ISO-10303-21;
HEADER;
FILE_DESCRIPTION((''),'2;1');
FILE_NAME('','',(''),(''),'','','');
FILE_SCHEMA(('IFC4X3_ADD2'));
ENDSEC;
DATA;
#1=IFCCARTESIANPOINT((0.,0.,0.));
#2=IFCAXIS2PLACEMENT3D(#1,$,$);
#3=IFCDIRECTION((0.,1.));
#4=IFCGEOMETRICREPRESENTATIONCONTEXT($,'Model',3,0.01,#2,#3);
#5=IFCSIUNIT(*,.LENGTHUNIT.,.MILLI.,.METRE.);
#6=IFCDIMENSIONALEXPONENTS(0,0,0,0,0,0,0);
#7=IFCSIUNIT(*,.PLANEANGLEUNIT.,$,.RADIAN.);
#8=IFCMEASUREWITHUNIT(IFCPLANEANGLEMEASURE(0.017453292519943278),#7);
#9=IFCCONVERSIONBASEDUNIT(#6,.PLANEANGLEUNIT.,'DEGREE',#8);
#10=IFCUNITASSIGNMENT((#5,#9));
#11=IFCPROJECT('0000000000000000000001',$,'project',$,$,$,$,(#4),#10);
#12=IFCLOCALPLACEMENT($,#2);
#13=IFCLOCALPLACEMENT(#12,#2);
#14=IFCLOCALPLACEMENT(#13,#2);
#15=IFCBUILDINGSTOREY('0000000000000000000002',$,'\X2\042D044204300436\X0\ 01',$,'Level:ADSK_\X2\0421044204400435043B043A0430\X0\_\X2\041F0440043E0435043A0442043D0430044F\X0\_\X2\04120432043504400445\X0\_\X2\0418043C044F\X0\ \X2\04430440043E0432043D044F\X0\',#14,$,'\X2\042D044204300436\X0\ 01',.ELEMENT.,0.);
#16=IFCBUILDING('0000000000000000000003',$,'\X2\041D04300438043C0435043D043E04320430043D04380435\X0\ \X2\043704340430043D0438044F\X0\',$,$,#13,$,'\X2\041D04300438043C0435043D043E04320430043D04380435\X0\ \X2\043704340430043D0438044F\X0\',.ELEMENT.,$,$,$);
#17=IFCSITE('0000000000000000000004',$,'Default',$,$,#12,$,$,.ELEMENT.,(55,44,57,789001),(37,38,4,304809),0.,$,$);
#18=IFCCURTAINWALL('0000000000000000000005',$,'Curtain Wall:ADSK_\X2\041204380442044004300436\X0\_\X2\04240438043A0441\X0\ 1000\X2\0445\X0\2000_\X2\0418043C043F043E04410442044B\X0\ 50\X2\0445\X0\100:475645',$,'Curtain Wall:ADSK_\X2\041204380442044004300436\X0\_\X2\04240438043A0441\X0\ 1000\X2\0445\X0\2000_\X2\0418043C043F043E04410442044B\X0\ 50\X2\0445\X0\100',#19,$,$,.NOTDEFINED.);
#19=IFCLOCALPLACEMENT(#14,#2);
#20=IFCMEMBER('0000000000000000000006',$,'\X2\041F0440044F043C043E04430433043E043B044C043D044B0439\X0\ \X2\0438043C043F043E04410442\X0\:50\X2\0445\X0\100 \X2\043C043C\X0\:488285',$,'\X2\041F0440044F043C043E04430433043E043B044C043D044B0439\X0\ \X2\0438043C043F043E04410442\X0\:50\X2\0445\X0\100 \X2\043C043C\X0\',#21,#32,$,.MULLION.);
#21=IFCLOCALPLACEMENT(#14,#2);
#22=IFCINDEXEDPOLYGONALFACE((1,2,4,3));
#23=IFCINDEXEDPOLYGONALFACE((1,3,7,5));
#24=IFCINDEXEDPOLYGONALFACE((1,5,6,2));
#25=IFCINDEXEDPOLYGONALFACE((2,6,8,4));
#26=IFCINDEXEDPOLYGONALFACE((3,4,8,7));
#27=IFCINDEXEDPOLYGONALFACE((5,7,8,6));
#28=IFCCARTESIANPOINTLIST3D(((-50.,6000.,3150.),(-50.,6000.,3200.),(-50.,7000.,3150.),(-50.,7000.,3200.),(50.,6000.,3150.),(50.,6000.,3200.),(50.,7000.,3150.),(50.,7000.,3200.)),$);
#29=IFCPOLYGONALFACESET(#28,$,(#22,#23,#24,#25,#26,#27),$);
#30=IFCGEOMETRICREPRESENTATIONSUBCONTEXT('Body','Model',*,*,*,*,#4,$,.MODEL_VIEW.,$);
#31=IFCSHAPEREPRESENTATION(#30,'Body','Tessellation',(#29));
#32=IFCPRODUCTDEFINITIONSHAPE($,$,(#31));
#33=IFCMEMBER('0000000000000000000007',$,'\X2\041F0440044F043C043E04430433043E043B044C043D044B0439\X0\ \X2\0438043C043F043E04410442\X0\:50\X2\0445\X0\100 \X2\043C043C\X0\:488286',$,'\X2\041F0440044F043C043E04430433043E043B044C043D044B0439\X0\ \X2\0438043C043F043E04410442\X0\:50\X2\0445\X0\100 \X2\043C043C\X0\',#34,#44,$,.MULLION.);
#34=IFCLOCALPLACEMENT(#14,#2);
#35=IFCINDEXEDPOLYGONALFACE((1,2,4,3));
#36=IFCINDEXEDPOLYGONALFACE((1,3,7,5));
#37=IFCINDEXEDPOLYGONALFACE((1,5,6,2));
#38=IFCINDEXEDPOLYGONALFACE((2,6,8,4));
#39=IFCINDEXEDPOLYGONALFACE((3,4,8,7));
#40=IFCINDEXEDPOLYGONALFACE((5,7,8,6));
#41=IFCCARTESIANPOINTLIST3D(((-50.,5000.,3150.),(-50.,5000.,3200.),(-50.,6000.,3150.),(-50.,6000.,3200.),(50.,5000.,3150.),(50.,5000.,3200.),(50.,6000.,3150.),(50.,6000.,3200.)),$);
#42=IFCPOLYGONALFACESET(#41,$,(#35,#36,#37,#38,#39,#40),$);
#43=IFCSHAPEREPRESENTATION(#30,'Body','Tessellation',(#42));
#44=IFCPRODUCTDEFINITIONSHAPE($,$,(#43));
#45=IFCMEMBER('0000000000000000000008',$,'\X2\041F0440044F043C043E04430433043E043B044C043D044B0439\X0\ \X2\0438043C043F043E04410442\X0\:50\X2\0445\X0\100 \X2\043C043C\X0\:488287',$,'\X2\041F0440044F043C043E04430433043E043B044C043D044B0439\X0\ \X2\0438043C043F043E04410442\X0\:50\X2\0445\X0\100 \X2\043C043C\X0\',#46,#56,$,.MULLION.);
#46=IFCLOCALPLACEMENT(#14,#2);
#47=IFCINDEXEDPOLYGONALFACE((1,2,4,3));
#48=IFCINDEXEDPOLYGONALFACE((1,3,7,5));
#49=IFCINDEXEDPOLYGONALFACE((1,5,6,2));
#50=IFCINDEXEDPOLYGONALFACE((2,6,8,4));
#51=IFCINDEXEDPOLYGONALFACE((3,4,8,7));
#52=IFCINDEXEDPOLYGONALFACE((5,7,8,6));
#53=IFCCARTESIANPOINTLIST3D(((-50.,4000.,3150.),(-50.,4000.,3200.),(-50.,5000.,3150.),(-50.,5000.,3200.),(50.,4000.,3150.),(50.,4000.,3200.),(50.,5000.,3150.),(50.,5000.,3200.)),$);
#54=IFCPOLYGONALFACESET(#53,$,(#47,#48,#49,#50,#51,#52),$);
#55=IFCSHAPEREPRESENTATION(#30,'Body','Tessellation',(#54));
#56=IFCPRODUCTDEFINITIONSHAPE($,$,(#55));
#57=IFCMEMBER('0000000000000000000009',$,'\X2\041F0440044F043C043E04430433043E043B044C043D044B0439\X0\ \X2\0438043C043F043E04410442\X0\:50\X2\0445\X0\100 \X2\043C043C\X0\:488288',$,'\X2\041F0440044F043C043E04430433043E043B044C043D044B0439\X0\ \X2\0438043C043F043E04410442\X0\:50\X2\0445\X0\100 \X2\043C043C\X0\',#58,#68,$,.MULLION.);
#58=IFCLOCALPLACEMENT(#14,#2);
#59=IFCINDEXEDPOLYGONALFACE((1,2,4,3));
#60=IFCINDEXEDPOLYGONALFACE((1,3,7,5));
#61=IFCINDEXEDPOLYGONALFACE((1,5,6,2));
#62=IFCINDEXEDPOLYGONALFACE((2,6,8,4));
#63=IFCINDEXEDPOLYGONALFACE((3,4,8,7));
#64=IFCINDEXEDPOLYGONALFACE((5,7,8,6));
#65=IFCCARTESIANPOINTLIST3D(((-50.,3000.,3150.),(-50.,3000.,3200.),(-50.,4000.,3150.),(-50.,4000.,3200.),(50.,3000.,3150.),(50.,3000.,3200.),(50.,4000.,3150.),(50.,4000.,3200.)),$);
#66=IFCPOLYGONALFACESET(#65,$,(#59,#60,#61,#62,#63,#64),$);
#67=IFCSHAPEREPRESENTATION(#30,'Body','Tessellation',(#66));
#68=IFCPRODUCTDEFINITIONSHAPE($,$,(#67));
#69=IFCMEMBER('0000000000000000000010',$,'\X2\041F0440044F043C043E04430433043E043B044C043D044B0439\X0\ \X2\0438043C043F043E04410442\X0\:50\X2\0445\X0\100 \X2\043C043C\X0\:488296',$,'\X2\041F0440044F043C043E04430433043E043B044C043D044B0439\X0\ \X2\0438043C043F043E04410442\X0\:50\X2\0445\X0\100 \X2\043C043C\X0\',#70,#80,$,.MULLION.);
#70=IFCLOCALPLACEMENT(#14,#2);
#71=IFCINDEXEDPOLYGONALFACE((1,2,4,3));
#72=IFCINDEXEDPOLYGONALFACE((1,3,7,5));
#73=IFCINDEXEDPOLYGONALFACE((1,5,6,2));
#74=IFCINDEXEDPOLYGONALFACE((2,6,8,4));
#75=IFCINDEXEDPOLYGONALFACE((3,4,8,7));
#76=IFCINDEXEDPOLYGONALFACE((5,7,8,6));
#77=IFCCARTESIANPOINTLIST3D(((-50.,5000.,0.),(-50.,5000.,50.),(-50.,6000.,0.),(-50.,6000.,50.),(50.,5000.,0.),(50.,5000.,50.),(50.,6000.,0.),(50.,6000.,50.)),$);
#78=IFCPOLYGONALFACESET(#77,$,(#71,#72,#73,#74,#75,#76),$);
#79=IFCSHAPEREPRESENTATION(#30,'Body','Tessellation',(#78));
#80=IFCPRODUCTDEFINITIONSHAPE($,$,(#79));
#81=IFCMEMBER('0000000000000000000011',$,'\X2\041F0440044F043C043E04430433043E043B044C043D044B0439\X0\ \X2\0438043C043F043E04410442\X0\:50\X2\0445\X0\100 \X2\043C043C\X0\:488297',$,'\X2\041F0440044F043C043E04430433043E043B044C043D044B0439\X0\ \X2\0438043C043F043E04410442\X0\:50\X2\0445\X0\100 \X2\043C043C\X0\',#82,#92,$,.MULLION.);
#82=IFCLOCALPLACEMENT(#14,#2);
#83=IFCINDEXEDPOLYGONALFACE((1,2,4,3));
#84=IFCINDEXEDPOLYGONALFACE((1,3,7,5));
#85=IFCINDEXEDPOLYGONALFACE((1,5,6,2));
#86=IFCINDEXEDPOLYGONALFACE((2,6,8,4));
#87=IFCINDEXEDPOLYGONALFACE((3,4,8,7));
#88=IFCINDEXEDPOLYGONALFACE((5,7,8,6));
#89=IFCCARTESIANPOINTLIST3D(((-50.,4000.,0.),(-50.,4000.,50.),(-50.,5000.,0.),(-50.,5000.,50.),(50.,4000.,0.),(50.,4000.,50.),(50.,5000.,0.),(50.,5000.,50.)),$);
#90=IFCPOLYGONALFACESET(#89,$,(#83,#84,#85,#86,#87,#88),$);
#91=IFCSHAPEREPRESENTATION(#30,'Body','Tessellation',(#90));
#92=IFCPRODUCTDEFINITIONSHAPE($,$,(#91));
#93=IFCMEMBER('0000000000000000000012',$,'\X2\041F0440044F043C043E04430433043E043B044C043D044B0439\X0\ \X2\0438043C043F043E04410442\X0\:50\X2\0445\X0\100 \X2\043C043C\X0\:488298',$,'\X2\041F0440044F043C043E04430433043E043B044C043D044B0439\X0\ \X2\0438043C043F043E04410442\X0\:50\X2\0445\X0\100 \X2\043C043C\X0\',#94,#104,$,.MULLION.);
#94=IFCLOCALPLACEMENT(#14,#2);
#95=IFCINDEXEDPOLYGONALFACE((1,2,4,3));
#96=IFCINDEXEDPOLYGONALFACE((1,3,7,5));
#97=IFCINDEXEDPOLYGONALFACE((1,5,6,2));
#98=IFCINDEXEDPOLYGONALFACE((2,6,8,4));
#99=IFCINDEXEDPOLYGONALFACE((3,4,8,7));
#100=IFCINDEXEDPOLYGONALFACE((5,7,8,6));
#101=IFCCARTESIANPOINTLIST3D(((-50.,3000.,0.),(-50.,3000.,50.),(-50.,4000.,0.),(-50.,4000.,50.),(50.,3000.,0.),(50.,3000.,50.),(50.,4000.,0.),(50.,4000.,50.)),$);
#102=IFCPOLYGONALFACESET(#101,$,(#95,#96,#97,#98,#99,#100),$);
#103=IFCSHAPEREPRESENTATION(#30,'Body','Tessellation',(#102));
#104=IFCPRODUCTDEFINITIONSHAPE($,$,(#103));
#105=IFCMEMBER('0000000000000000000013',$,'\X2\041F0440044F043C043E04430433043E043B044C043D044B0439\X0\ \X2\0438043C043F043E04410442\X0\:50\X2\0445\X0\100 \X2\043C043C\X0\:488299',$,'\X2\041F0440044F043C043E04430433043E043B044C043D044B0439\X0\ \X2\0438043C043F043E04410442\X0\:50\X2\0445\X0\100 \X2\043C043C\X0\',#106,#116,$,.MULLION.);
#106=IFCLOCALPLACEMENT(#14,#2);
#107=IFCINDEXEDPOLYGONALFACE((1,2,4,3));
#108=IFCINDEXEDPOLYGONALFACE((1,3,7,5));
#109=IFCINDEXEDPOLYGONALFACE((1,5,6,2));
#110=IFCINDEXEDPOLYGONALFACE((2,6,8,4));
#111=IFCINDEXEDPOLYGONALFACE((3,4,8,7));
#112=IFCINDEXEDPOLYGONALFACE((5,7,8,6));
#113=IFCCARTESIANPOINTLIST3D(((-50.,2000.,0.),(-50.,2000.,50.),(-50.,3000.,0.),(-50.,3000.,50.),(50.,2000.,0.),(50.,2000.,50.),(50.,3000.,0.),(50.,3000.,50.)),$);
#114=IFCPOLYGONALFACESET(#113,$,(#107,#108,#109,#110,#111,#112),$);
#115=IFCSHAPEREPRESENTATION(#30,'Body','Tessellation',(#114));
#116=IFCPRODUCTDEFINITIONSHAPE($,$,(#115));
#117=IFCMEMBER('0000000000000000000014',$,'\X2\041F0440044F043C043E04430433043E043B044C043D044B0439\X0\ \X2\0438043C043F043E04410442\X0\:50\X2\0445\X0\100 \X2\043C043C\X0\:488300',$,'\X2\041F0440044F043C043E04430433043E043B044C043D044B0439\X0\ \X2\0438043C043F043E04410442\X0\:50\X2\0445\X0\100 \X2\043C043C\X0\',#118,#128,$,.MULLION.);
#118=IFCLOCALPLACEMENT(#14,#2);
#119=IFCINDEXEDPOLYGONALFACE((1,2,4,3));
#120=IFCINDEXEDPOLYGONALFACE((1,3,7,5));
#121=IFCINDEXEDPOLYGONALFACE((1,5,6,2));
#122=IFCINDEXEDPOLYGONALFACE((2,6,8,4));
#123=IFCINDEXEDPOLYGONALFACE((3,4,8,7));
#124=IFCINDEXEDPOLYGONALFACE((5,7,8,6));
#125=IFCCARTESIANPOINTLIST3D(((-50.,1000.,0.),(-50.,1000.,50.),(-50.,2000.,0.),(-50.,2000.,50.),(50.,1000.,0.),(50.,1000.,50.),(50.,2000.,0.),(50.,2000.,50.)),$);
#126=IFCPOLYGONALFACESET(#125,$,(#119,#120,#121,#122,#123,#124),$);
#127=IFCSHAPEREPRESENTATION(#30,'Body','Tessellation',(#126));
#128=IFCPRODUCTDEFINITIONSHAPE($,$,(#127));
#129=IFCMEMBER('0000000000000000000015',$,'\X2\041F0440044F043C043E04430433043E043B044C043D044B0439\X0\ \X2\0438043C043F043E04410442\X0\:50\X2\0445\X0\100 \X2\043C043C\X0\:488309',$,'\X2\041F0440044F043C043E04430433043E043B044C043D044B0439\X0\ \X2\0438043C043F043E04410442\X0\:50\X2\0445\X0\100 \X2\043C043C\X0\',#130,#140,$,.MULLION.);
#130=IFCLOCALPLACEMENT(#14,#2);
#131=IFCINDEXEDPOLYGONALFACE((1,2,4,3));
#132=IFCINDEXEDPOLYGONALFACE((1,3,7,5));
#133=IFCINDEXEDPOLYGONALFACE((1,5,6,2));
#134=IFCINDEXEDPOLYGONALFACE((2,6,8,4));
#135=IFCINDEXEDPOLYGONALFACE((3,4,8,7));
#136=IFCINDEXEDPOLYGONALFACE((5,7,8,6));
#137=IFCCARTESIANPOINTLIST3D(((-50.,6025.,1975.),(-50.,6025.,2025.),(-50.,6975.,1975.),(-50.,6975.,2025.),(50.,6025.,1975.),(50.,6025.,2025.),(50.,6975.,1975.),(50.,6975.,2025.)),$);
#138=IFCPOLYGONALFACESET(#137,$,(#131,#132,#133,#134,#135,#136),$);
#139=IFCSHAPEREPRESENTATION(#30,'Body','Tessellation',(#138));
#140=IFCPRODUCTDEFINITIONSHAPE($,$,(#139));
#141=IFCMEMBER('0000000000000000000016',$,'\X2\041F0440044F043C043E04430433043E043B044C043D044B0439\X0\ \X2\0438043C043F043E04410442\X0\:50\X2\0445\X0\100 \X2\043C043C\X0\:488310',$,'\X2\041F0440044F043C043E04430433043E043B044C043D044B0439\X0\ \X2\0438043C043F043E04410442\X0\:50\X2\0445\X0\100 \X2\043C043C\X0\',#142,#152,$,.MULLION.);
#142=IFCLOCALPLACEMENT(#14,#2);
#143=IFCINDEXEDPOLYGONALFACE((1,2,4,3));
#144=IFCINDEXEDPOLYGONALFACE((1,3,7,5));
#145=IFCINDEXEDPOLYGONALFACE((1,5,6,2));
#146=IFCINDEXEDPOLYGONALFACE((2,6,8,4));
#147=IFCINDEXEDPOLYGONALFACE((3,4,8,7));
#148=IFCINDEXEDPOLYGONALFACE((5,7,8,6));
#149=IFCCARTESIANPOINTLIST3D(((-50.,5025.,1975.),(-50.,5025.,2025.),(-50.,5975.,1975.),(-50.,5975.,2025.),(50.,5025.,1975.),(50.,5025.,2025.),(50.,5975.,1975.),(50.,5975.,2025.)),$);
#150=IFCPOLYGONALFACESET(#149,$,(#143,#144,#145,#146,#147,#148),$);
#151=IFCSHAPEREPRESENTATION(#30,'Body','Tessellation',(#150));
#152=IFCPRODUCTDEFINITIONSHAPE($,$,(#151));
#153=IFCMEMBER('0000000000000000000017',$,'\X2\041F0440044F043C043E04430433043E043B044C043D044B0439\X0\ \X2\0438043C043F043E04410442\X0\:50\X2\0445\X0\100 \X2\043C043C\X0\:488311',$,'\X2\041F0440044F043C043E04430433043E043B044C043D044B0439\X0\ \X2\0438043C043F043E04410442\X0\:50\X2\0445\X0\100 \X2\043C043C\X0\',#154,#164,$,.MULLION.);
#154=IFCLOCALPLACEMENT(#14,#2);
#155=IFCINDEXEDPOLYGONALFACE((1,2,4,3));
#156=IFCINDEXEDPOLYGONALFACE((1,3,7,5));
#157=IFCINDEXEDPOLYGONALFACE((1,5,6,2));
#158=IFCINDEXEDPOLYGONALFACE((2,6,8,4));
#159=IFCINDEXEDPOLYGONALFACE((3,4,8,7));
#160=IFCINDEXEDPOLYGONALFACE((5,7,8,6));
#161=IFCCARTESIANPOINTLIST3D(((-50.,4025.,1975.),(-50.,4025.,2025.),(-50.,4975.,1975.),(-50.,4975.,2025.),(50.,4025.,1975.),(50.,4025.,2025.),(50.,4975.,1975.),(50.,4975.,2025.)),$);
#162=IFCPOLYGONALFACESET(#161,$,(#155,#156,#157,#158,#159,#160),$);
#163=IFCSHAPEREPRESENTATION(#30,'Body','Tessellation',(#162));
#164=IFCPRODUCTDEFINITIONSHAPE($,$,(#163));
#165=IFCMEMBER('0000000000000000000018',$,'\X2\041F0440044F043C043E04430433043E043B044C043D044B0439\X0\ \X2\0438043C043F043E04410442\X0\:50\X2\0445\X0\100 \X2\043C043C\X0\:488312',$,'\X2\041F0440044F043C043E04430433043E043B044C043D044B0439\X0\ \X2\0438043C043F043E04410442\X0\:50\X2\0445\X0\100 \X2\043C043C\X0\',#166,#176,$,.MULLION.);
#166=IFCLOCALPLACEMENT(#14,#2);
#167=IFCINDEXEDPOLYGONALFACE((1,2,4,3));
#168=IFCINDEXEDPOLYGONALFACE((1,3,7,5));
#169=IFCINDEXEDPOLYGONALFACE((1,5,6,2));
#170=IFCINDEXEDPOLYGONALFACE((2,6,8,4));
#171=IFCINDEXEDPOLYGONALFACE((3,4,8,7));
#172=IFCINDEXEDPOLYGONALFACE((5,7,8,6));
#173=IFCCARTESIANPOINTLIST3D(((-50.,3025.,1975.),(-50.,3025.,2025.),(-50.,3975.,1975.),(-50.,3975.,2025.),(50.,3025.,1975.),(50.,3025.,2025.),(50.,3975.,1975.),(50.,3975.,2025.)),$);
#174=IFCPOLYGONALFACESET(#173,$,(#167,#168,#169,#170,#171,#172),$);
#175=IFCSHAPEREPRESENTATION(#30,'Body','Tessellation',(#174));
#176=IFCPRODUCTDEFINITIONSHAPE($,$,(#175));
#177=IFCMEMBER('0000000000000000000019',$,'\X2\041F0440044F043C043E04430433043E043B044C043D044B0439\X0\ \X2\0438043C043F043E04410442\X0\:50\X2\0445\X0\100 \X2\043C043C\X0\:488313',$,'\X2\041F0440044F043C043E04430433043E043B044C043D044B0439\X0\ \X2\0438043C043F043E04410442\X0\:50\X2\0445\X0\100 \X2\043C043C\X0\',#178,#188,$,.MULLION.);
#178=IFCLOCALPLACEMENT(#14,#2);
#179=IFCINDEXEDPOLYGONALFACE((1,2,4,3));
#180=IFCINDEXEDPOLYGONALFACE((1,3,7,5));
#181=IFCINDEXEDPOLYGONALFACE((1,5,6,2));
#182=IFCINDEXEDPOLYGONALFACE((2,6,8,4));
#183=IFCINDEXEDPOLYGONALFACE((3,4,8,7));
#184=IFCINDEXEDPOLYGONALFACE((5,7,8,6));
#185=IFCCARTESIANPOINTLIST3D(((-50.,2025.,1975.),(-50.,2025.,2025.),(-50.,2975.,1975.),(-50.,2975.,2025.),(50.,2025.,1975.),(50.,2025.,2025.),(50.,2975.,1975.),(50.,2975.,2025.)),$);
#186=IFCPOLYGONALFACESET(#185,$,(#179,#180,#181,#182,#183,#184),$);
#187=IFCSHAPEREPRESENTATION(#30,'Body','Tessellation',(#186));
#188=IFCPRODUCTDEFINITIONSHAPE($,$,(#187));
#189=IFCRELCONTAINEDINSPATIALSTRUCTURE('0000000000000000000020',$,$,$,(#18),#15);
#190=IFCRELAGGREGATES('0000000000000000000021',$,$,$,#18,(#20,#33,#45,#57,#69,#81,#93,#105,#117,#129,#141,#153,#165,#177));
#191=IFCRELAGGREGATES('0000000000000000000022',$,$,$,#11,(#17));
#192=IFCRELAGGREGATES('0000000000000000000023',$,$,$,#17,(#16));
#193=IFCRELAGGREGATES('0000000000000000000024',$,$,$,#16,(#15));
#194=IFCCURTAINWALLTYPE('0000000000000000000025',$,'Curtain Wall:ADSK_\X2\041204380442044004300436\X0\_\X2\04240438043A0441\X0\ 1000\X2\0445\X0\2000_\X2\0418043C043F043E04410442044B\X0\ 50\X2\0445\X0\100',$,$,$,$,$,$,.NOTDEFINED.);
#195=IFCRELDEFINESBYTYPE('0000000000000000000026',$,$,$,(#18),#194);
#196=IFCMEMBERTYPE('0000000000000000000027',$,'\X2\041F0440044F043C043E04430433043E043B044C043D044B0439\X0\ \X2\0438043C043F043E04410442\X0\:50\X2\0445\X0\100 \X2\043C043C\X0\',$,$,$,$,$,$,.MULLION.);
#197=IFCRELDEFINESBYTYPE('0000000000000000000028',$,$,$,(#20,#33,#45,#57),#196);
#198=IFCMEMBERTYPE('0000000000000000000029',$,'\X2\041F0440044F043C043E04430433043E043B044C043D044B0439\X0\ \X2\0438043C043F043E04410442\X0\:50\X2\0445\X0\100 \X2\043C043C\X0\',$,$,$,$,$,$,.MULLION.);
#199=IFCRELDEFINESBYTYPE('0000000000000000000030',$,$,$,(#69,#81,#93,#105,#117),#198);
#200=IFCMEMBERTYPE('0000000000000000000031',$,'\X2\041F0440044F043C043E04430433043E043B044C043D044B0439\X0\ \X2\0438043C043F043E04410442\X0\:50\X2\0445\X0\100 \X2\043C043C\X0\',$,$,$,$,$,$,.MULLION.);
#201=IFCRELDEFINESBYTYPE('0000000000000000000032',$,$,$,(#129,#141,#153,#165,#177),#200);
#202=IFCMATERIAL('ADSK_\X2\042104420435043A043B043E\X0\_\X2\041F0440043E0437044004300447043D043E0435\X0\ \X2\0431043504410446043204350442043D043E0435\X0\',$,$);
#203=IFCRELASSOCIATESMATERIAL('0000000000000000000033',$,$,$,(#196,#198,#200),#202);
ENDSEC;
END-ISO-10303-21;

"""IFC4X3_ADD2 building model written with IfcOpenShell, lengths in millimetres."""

from ifc_helpers import new_model, entity, si_unit, converted_unit, direction, frame, frame_2d, origin, place, context, subcontext, project, spatial, rectangle, extrude, source, transform, mapped, material, material_profile, profile_set, type_object, type_shapes, element, aggregate, save


model = new_model("IFC4X3_ADD2")

# Units and contexts
model_context = context("Model", 3, precision=0.01, world=origin(), true_north=direction((0.0, 1.0)))
body_context = subcontext(model_context, "Body", "Model", "MODEL_VIEW")
ifc_project = project(units=[si_unit("LENGTHUNIT", "METRE", prefix="MILLI"), converted_unit("PLANEANGLEUNIT", "DEGREE", entity("IfcPlaneAngleMeasure", 0.017453292519943278), si_unit("PLANEANGLEUNIT", "RADIAN"), dimensions=[0, 0, 0, 0, 0, 0, 0])], contexts=[model_context])

# Site, building, storey
site_placement = place(None, origin())
site = spatial("IfcSite", under=ifc_project, at=site_placement, Name="Default", CompositionType="ELEMENT", RefLatitude=(55, 44, 57, 789001), RefLongitude=(37, 38, 4, 304809), RefElevation=0.0)
building_placement = place(site_placement, origin())
building = spatial("IfcBuilding", under=site, at=building_placement, Name="Наименование здания", LongName="Наименование здания", CompositionType="ELEMENT")
storey_placement = place(building_placement, origin())
storey = spatial("IfcBuildingStorey", under=building, at=storey_placement, Name="Этаж 01", ObjectType="Level:ADSK_Стрелка_Проектная_Вверх_Имя уровня", LongName="Этаж 01", CompositionType="ELEMENT", Elevation=0.0)

# Curtain wall, members
curtain_wall_type = type_object("IfcCurtainWallType", Name="Curtain Wall:ADSK_Витраж_Фикс 1000х2000_Импосты 50х100", PredefinedType="NOTDEFINED")
curtain_wall_placement = place(storey_placement, origin())
curtain_wall = element("IfcCurtainWall", 1, at=curtain_wall_placement, inside=storey, type_object=curtain_wall_type, Name="Curtain Wall:ADSK_Витраж_Фикс 1000х2000_Импосты 50х100:475645", ObjectType="Curtain Wall:ADSK_Витраж_Фикс 1000х2000_Импосты 50х100", PredefinedType="NOTDEFINED")
ifc_material = material(Name="ADSK_Стекло_Прозрачное бесцветное")
ifc_material_profile = material_profile(ifc_material, rectangle(XDim=50.0, YDim=100.0, at=frame_2d((0.0, 0.0), x_axis=(1.0, 0.0))), Name="50х100 мм")
ifc_profile_set = profile_set([ifc_material_profile], Name="50х100 мм")
member_type_1 = type_object("IfcMemberType", Name="Прямоугольный импост:50х100 мм", PredefinedType="MULLION", material=ifc_profile_set)
shared_shape_1 = source(origin(), body_context, "Body", "SweptSolid", [
    extrude(rectangle(XDim=50.0, YDim=100.0, at=frame_2d((0.0, 0.0), x_axis=(1.0, 0.0))), frame((-25.0, 0.0, -1000.0), z_axis=(0.0, 0.0, 1.0), x_axis=(-1.0, 0.0, 0.0)), (0.0, 0.0, 1.0), 1000.0),
])
type_shapes(member_type_1, [shared_shape_1])
member_1_placement = place(curtain_wall_placement, frame((0.0, 6000.0, 3200.0), z_axis=(0.0, -1.0, 0.0), x_axis=(0.0, 0.0, 1.0)))
member_1 = element("IfcMember", 2, at=member_1_placement, type_object=member_type_1, Name="Прямоугольный импост:50х100 мм:488285", ObjectType="Прямоугольный импост:50х100 мм", PredefinedType="MULLION", context=body_context, shape_type="MappedRepresentation", body=[
    mapped(shared_shape_1, transform((0.0, 0.0, 0.0), scale=1.0)),
])
member_2_placement = place(curtain_wall_placement, frame((0.0, 5000.0, 3200.0), z_axis=(0.0, -1.0, 0.0), x_axis=(0.0, 0.0, 1.0)))
member_2 = element("IfcMember", 3, at=member_2_placement, type_object=member_type_1, Name="Прямоугольный импост:50х100 мм:488286", ObjectType="Прямоугольный импост:50х100 мм", PredefinedType="MULLION", context=body_context, shape_type="MappedRepresentation", body=[
    mapped(shared_shape_1, transform((0.0, 0.0, 0.0), scale=1.0)),
])
member_3_placement = place(curtain_wall_placement, frame((0.0, 4000.0, 3200.0), z_axis=(0.0, -1.0, 0.0), x_axis=(0.0, 0.0, 1.0)))
member_3 = element("IfcMember", 4, at=member_3_placement, type_object=member_type_1, Name="Прямоугольный импост:50х100 мм:488287", ObjectType="Прямоугольный импост:50х100 мм", PredefinedType="MULLION", context=body_context, shape_type="MappedRepresentation", body=[
    mapped(shared_shape_1, transform((0.0, 0.0, 0.0), scale=1.0)),
])
member_4_placement = place(curtain_wall_placement, frame((0.0, 3000.0, 3200.0), z_axis=(0.0, -1.0, 0.0), x_axis=(0.0, 0.0, 1.0)))
member_4 = element("IfcMember", 5, at=member_4_placement, type_object=member_type_1, Name="Прямоугольный импост:50х100 мм:488288", ObjectType="Прямоугольный импост:50х100 мм", PredefinedType="MULLION", context=body_context, shape_type="MappedRepresentation", body=[
    mapped(shared_shape_1, transform((0.0, 0.0, 0.0), scale=1.0)),
])
member_type_2 = type_object("IfcMemberType", Name="Прямоугольный импост:50х100 мм", PredefinedType="MULLION", material=ifc_profile_set)
shared_shape_2 = source(origin(), body_context, "Body", "SweptSolid", [
    extrude(rectangle(XDim=50.0, YDim=100.0, at=frame_2d((0.0, 0.0), x_axis=(1.0, 0.0))), frame((-25.0, 0.0, -1000.0), z_axis=(0.0, 0.0, 1.0), x_axis=(-1.0, 0.0, 0.0)), (0.0, 0.0, 1.0), 1000.0),
])
type_shapes(member_type_2, [shared_shape_2])
member_5_placement = place(curtain_wall_placement, frame((0.0, 6000.0, 0.0), z_axis=(0.0, 1.0, 0.0), x_axis=(0.0, 0.0, -1.0)))
member_5 = element("IfcMember", 6, at=member_5_placement, type_object=member_type_2, Name="Прямоугольный импост:50х100 мм:488296", ObjectType="Прямоугольный импост:50х100 мм", PredefinedType="MULLION", context=body_context, shape_type="MappedRepresentation", body=[
    mapped(shared_shape_2, transform((0.0, 0.0, 0.0), scale=1.0)),
])
member_6_placement = place(curtain_wall_placement, frame((0.0, 5000.0, 0.0), z_axis=(0.0, 1.0, 0.0), x_axis=(0.0, 0.0, -1.0)))
member_6 = element("IfcMember", 7, at=member_6_placement, type_object=member_type_2, Name="Прямоугольный импост:50х100 мм:488297", ObjectType="Прямоугольный импост:50х100 мм", PredefinedType="MULLION", context=body_context, shape_type="MappedRepresentation", body=[
    mapped(shared_shape_2, transform((0.0, 0.0, 0.0), scale=1.0)),
])
member_7_placement = place(curtain_wall_placement, frame((0.0, 4000.0, 0.0), z_axis=(0.0, 1.0, 0.0), x_axis=(0.0, 0.0, -1.0)))
member_7 = element("IfcMember", 8, at=member_7_placement, type_object=member_type_2, Name="Прямоугольный импост:50х100 мм:488298", ObjectType="Прямоугольный импост:50х100 мм", PredefinedType="MULLION", context=body_context, shape_type="MappedRepresentation", body=[
    mapped(shared_shape_2, transform((0.0, 0.0, 0.0), scale=1.0)),
])
member_8_placement = place(curtain_wall_placement, frame((0.0, 3000.0, 0.0), z_axis=(0.0, 1.0, 0.0), x_axis=(0.0, 0.0, -1.0)))
member_8 = element("IfcMember", 9, at=member_8_placement, type_object=member_type_2, Name="Прямоугольный импост:50х100 мм:488299", ObjectType="Прямоугольный импост:50х100 мм", PredefinedType="MULLION", context=body_context, shape_type="MappedRepresentation", body=[
    mapped(shared_shape_2, transform((0.0, 0.0, 0.0), scale=1.0)),
])
member_9_placement = place(curtain_wall_placement, frame((0.0, 2000.0, 0.0), z_axis=(0.0, 1.0, 0.0), x_axis=(0.0, 0.0, -1.0)))
member_9 = element("IfcMember", 10, at=member_9_placement, type_object=member_type_2, Name="Прямоугольный импост:50х100 мм:488300", ObjectType="Прямоугольный импост:50х100 мм", PredefinedType="MULLION", context=body_context, shape_type="MappedRepresentation", body=[
    mapped(shared_shape_2, transform((0.0, 0.0, 0.0), scale=1.0)),
])
member_type_3 = type_object("IfcMemberType", Name="Прямоугольный импост:50х100 мм", PredefinedType="MULLION", material=ifc_profile_set)
shared_shape_3 = source(origin(), body_context, "Body", "SweptSolid", [
    extrude(rectangle(XDim=50.0, YDim=100.0, at=frame_2d((0.0, 0.0), x_axis=(1.0, 0.0))), frame((0.0, 0.0, -950.0), z_axis=(0.0, 0.0, 1.0), x_axis=(-1.0, 0.0, 0.0)), (0.0, 0.0, 1.0), 950.0),
])
type_shapes(member_type_3, [shared_shape_3])
member_10_placement = place(curtain_wall_placement, frame((0.0, 6025.0, 2000.0), z_axis=(0.0, -1.0, 0.0), x_axis=(0.0, 0.0, 1.0)))
member_10 = element("IfcMember", 11, at=member_10_placement, type_object=member_type_3, Name="Прямоугольный импост:50х100 мм:488309", ObjectType="Прямоугольный импост:50х100 мм", PredefinedType="MULLION", context=body_context, shape_type="MappedRepresentation", body=[
    mapped(shared_shape_3, transform((0.0, 0.0, 0.0), scale=1.0)),
])
member_11_placement = place(curtain_wall_placement, frame((0.0, 5025.0, 2000.0), z_axis=(0.0, -1.0, 0.0), x_axis=(0.0, 0.0, 1.0)))
member_11 = element("IfcMember", 12, at=member_11_placement, type_object=member_type_3, Name="Прямоугольный импост:50х100 мм:488310", ObjectType="Прямоугольный импост:50х100 мм", PredefinedType="MULLION", context=body_context, shape_type="MappedRepresentation", body=[
    mapped(shared_shape_3, transform((0.0, 0.0, 0.0), scale=1.0)),
])
member_12_placement = place(curtain_wall_placement, frame((0.0, 4025.0, 2000.0), z_axis=(0.0, -1.0, 0.0), x_axis=(0.0, 0.0, 1.0)))
member_12 = element("IfcMember", 13, at=member_12_placement, type_object=member_type_3, Name="Прямоугольный импост:50х100 мм:488311", ObjectType="Прямоугольный импост:50х100 мм", PredefinedType="MULLION", context=body_context, shape_type="MappedRepresentation", body=[
    mapped(shared_shape_3, transform((0.0, 0.0, 0.0), scale=1.0)),
])
member_13_placement = place(curtain_wall_placement, frame((0.0, 3025.0, 2000.0), z_axis=(0.0, -1.0, 0.0), x_axis=(0.0, 0.0, 1.0)))
member_13 = element("IfcMember", 14, at=member_13_placement, type_object=member_type_3, Name="Прямоугольный импост:50х100 мм:488312", ObjectType="Прямоугольный импост:50х100 мм", PredefinedType="MULLION", context=body_context, shape_type="MappedRepresentation", body=[
    mapped(shared_shape_3, transform((0.0, 0.0, 0.0), scale=1.0)),
])
member_14_placement = place(curtain_wall_placement, frame((0.0, 2025.0, 2000.0), z_axis=(0.0, -1.0, 0.0), x_axis=(0.0, 0.0, 1.0)))
member_14 = element("IfcMember", 15, at=member_14_placement, type_object=member_type_3, Name="Прямоугольный импост:50х100 мм:488313", ObjectType="Прямоугольный импост:50х100 мм", PredefinedType="MULLION", context=body_context, shape_type="MappedRepresentation", body=[
    mapped(shared_shape_3, transform((0.0, 0.0, 0.0), scale=1.0)),
])
aggregate(curtain_wall, [member_1, member_2, member_3, member_4, member_5, member_6, member_7, member_8, member_9, member_10, member_11, member_12, member_13, member_14])

save(model, "model.ifc")
